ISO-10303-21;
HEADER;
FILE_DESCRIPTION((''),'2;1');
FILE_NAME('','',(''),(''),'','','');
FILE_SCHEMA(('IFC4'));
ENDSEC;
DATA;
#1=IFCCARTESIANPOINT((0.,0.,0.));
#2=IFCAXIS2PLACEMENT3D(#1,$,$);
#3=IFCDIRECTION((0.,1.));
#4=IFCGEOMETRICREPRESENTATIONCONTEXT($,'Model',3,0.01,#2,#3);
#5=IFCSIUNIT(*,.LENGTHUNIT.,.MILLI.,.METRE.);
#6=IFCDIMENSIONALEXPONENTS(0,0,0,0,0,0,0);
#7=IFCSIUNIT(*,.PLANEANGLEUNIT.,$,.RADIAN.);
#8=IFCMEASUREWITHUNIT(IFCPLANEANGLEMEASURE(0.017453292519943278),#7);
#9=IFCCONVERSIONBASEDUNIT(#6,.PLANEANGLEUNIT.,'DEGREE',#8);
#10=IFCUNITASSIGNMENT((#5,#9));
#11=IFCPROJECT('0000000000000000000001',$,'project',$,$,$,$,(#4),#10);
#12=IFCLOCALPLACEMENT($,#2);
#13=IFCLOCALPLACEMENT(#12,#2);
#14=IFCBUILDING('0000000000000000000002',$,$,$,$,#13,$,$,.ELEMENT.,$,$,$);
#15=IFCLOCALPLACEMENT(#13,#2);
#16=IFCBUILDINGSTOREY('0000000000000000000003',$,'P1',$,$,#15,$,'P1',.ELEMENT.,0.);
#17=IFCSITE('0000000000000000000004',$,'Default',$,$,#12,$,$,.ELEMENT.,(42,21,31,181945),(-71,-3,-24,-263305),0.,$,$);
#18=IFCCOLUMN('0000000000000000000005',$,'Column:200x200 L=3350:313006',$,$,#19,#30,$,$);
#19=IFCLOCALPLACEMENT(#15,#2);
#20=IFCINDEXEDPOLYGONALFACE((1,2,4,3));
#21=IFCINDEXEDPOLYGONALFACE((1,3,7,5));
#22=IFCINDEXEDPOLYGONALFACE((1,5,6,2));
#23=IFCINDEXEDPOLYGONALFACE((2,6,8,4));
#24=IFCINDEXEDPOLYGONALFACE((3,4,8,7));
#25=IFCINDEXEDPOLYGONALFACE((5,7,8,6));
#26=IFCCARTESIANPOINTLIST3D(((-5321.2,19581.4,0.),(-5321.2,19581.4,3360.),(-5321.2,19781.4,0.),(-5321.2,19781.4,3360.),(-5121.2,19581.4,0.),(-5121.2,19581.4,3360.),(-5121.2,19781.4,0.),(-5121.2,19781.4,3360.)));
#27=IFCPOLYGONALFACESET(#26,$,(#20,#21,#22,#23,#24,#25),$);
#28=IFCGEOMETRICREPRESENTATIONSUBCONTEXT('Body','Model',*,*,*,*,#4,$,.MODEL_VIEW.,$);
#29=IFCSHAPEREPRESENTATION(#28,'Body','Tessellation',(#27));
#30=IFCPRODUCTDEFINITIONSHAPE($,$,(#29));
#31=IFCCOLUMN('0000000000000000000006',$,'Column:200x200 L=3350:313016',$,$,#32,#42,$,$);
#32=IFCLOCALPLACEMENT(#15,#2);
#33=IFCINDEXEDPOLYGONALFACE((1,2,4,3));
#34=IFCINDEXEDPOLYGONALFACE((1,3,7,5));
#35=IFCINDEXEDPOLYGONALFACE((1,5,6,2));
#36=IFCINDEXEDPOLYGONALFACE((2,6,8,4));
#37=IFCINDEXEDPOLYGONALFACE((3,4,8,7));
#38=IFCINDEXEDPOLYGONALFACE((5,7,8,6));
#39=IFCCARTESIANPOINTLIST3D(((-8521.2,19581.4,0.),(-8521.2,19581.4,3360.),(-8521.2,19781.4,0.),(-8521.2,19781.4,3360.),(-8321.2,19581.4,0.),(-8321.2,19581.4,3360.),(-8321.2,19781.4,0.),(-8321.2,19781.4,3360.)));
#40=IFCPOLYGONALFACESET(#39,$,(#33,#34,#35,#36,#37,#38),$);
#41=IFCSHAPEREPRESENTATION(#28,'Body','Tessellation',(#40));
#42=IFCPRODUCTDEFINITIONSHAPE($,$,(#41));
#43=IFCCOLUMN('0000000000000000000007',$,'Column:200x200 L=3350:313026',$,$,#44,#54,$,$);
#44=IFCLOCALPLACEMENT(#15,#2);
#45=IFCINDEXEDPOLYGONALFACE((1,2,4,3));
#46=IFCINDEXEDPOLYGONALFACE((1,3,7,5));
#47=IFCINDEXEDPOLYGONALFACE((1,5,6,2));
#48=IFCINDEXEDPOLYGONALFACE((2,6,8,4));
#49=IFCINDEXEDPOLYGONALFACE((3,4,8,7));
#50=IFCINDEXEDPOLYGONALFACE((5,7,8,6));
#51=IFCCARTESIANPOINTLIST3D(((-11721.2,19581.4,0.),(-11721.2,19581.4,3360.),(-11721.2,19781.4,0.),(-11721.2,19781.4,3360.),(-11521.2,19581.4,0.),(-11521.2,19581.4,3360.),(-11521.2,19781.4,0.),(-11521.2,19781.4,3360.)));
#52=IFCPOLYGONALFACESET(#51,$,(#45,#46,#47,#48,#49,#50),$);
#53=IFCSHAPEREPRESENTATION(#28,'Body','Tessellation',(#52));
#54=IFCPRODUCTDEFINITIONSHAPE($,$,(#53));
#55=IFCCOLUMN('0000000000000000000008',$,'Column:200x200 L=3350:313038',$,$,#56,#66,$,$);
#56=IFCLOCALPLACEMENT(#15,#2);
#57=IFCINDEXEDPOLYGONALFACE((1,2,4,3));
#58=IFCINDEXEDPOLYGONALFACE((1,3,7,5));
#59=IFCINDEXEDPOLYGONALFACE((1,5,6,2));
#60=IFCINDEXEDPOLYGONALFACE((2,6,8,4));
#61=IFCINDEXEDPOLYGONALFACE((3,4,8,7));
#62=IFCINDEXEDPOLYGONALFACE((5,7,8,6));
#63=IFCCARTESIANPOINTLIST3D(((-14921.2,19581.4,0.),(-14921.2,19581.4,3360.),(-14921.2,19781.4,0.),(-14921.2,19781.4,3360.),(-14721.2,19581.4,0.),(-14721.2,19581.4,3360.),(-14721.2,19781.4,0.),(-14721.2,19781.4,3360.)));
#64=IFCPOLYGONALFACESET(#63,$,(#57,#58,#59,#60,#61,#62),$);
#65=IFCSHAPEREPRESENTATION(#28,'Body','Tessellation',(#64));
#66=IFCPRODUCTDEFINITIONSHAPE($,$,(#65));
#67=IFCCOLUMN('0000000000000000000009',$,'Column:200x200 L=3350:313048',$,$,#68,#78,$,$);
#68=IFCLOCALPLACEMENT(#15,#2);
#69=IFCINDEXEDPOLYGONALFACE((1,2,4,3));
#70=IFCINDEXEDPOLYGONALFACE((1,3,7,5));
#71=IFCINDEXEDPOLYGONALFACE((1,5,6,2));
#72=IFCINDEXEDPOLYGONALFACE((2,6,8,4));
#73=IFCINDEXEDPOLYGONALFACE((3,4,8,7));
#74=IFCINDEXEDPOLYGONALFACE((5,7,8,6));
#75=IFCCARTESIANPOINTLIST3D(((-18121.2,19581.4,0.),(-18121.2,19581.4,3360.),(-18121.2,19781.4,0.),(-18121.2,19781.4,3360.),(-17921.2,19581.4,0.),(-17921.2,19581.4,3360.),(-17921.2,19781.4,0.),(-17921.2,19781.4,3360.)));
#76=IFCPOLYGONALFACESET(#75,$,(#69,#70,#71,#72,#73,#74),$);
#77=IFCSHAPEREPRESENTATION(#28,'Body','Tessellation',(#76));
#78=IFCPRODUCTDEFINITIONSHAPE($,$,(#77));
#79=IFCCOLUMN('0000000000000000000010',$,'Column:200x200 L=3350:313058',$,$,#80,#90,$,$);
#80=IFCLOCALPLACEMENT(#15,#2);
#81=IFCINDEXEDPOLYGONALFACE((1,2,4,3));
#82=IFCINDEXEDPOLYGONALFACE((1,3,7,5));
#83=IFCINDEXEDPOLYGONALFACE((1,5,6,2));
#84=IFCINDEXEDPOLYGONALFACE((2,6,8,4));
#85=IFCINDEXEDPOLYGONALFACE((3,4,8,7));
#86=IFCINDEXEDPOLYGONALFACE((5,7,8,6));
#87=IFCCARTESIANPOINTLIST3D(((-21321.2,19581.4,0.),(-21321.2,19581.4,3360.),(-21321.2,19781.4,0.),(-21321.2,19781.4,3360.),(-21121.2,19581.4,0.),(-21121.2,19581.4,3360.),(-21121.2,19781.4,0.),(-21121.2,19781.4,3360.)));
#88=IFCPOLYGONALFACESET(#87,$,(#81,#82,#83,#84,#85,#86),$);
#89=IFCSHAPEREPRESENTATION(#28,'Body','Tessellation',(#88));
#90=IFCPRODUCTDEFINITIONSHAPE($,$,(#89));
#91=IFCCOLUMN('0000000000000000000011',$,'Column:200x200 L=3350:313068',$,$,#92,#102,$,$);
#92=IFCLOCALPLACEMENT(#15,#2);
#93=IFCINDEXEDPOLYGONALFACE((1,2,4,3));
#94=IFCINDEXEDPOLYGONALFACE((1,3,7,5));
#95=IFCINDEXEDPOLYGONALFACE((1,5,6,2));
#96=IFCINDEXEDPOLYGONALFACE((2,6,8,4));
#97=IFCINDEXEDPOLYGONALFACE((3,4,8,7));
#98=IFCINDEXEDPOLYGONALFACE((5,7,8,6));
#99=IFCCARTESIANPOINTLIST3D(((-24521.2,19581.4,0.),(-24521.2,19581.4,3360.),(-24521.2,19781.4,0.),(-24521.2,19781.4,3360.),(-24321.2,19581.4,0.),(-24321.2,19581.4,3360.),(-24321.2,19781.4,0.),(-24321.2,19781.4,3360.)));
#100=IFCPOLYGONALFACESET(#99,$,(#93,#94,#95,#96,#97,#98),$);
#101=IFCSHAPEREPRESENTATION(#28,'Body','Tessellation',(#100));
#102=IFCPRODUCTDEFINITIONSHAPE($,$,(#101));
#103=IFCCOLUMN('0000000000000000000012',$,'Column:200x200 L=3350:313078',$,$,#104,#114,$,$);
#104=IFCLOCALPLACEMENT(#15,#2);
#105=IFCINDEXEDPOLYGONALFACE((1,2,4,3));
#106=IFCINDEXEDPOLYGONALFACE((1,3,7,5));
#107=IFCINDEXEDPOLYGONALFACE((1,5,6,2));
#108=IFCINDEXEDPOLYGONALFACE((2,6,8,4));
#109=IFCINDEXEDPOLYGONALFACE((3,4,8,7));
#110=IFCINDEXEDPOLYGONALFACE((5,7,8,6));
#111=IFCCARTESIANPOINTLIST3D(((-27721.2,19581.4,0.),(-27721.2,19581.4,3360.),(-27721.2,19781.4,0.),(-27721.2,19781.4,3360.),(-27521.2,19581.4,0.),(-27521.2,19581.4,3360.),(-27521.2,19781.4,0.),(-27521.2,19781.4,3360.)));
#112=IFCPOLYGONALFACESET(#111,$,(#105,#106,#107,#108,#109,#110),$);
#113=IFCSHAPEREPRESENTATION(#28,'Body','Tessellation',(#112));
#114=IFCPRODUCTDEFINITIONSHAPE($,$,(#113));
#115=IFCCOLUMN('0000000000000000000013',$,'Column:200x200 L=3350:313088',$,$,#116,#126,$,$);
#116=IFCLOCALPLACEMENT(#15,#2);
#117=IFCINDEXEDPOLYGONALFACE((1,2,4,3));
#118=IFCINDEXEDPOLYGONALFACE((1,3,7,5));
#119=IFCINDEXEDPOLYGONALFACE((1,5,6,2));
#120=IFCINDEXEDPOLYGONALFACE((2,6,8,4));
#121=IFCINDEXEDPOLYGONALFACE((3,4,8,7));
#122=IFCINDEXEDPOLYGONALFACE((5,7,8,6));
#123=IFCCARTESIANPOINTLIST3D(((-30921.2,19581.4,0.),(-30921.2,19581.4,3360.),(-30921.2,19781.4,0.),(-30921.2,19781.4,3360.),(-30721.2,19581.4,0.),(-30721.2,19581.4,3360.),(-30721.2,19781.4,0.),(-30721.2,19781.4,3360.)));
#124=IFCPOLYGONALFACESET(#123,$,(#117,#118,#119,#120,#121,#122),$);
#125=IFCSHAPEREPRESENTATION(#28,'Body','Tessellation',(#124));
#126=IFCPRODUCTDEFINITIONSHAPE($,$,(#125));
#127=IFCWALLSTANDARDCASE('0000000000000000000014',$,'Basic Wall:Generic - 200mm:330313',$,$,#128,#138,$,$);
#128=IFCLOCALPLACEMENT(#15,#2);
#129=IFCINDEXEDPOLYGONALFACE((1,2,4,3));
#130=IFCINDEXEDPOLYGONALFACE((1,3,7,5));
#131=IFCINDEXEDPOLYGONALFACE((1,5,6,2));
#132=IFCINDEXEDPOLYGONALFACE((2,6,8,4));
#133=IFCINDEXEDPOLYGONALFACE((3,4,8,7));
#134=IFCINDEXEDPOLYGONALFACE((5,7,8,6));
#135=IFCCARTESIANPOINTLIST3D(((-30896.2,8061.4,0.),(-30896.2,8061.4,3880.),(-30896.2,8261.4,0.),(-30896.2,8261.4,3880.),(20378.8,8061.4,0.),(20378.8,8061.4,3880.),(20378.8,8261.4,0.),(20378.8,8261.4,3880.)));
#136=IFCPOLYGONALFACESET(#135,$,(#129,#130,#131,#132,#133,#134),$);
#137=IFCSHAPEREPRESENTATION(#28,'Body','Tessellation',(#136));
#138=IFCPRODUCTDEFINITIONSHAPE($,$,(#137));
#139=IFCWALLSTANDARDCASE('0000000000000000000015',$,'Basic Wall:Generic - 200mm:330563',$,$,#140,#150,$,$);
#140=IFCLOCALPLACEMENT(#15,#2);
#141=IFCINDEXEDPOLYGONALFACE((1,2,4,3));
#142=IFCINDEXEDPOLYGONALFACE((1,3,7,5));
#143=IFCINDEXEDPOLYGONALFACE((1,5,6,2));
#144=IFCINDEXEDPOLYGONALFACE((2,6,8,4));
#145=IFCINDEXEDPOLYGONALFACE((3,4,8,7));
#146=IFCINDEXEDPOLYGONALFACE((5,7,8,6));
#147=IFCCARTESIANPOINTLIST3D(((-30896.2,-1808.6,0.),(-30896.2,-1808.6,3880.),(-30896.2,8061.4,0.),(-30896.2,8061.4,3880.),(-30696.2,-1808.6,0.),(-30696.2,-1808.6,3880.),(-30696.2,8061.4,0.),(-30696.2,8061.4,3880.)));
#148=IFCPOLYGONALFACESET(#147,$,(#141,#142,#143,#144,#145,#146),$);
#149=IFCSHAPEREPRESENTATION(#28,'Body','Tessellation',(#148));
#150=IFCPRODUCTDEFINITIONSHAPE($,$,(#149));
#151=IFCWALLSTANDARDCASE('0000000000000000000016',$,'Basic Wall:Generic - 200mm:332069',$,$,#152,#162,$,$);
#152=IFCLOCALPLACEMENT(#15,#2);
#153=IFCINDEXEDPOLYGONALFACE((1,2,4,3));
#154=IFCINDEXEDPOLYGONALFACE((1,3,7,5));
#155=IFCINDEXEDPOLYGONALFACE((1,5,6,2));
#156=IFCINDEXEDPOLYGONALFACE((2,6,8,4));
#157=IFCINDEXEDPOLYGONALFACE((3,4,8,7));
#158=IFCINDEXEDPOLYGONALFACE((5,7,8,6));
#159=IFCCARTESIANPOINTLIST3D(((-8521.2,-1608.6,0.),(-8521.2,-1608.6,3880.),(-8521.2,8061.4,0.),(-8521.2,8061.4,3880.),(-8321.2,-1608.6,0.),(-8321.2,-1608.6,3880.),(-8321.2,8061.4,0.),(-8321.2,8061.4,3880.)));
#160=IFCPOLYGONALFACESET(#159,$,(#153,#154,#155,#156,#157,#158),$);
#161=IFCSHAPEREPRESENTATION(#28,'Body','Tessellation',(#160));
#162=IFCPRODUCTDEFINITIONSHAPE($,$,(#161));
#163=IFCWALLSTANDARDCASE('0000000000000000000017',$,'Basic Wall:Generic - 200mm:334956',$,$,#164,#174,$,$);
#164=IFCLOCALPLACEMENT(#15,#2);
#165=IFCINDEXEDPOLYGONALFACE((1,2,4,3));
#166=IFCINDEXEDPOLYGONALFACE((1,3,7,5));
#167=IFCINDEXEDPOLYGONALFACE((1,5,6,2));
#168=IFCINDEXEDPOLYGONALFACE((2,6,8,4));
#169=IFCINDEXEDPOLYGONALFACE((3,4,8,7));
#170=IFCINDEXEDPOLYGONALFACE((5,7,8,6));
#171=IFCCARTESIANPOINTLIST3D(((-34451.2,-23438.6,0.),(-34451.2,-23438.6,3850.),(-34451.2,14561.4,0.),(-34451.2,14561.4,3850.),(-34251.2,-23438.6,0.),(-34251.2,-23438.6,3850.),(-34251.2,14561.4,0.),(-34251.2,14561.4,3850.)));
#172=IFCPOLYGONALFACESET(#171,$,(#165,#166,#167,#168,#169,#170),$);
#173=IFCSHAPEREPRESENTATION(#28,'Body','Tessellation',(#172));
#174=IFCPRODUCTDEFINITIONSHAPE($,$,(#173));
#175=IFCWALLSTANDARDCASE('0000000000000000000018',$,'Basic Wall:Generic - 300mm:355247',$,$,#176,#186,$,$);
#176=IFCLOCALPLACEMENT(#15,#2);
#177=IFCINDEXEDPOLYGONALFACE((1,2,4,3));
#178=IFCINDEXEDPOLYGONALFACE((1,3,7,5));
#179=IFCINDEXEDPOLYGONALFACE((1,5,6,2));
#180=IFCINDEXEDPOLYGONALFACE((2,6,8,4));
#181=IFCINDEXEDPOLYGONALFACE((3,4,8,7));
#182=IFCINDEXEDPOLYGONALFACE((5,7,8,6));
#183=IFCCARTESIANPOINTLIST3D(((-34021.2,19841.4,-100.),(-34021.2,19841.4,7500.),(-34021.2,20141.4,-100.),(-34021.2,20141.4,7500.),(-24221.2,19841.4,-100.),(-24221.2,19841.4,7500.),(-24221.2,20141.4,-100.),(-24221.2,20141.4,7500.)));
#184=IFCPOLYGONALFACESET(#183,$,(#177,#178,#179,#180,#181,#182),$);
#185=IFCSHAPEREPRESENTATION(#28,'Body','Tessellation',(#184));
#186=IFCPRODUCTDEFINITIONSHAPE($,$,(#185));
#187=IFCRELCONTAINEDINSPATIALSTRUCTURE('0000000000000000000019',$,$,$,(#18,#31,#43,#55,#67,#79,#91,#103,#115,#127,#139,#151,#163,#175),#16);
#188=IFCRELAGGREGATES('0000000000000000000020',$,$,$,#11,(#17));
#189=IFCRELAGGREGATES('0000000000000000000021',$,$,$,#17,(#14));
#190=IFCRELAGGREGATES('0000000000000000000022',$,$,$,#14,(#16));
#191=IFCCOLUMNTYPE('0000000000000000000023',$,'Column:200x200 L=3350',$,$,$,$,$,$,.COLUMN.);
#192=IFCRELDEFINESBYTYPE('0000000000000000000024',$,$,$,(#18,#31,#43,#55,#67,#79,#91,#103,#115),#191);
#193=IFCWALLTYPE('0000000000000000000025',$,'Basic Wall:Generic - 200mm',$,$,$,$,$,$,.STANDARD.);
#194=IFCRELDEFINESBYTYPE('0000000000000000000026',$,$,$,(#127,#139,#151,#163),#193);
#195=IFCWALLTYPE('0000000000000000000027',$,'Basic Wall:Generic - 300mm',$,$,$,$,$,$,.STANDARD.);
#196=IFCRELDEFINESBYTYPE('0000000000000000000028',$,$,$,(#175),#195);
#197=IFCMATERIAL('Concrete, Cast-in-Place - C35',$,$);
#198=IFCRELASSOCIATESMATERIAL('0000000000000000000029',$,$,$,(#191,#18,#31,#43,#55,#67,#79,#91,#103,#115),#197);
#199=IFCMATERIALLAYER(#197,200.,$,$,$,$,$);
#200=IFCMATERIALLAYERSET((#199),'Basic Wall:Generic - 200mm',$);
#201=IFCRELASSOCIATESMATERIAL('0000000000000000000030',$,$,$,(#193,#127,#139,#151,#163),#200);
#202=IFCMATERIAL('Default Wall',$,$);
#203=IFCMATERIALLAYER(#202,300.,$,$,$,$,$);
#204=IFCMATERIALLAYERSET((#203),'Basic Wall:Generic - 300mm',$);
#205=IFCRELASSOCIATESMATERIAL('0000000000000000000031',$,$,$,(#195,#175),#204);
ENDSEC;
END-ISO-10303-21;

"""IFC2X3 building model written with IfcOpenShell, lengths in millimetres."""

from ifc_helpers import new_model, entity, si_unit, converted_unit, direction, frame, frame_2d, origin, place, context, subcontext, project, spatial, rectangle, extrude, source, transform, mapped, material, layer, layer_set, layer_usage, type_object, type_shapes, element, save


model = new_model("IFC2X3")

# Units and contexts
model_context = context("Model", 3, precision=0.01, world=origin(), true_north=direction((0.0, 1.0)))
body_context = subcontext(model_context, "Body", "Model", "MODEL_VIEW")
ifc_project = project(units=[si_unit("LENGTHUNIT", "METRE", prefix="MILLI"), converted_unit("PLANEANGLEUNIT", "DEGREE", entity("IfcPlaneAngleMeasure", 0.017453292519943278), si_unit("PLANEANGLEUNIT", "RADIAN"), dimensions=[0, 0, 0, 0, 0, 0, 0])], contexts=[model_context])

# Site, building, storey
site_placement = place(None, origin())
site = spatial("IfcSite", under=ifc_project, at=site_placement, Name="Default", CompositionType="ELEMENT", RefLatitude=(42, 21, 31, 181945), RefLongitude=(-71, -3, -24, -263305), RefElevation=0.0)
building_placement = place(site_placement, origin())
building = spatial("IfcBuilding", under=site, at=building_placement, CompositionType="ELEMENT")
storey_placement = place(building_placement, origin())
storey = spatial("IfcBuildingStorey", under=building, at=storey_placement, Name="P1", LongName="P1", CompositionType="ELEMENT", Elevation=0.0)

# Columns
ifc_material_1 = material(Name="Concrete, Cast-in-Place - C35")
column_type_1 = type_object("IfcColumnType", Name="Column:200x200 L=3350", PredefinedType="COLUMN", material=ifc_material_1)
shared_shape_1 = source(origin(), body_context, "Body", "SweptSolid", [
    extrude(rectangle(XDim=200.0, YDim=200.0, at=frame_2d((0.0, 0.0), x_axis=(1.0, 0.0))), frame((0.0, 0.0, 0.0), z_axis=(0.0, 0.0, 1.0), x_axis=(-1.0, 0.0, 0.0)), (0.0, 0.0, 1.0), 3360.0),
])
type_shapes(column_type_1, [shared_shape_1])
for number, where, name in (
    (1, (-5221.2, 19681.4, 0.0), "Column:200x200 L=3350:313006"),
    (2, (-8421.2, 19681.4, 0.0), "Column:200x200 L=3350:313016"),
    (3, (-11621.2, 19681.4, 0.0), "Column:200x200 L=3350:313026"),
    (4, (-14821.2, 19681.4, 0.0), "Column:200x200 L=3350:313038"),
    (5, (-18021.2, 19681.4, 0.0), "Column:200x200 L=3350:313048"),
    (6, (-21221.2, 19681.4, 0.0), "Column:200x200 L=3350:313058"),
    (7, (-24421.2, 19681.4, 0.0), "Column:200x200 L=3350:313068"),
    (8, (-27621.2, 19681.4, 0.0), "Column:200x200 L=3350:313078"),
    (9, (-30821.2, 19681.4, 0.0), "Column:200x200 L=3350:313088"),
):
    element("IfcColumn", number, at=place(storey_placement, frame(where)), inside=storey, type_object=column_type_1, material=ifc_material_1, Name=name, context=body_context, shape_type="MappedRepresentation", body=[
        mapped(shared_shape_1, transform((0.0, 0.0, 0.0), scale=1.0)),
    ])

# Walls
ifc_layer_1 = layer(ifc_material_1, 200.0)
ifc_layer_set_1 = layer_set([ifc_layer_1], Name="Basic Wall:Generic - 200mm")
ifc_layer_usage_1 = layer_usage(ifc_layer_set_1, "AXIS2", "NEGATIVE", 100.0)
wall_type_1 = type_object("IfcWallType", Name="Basic Wall:Generic - 200mm", PredefinedType="STANDARD", material=ifc_layer_set_1)
wall_1_placement = place(storey_placement, frame((-30896.2, 8161.4, 0.0)))
element("IfcWallStandardCase", 10, at=wall_1_placement, inside=storey, type_object=wall_type_1, material=ifc_layer_usage_1, Name="Basic Wall:Generic - 200mm:330313", context=body_context, shape_type="SweptSolid", body=[
    extrude(rectangle(XDim=51275.0, YDim=200.0, at=frame_2d((25637.5, 0.0), x_axis=(-1.0, 0.0))), origin(), (0.0, 0.0, 1.0), 3880.0),
])
ifc_layer_usage_2 = layer_usage(ifc_layer_set_1, "AXIS2", "NEGATIVE", 100.0)
wall_2_placement = place(storey_placement, frame((-30796.2, 8061.4, 0.0), z_axis=(0.0, 0.0, 1.0), x_axis=(0.0, -1.0, 0.0)))
element("IfcWallStandardCase", 11, at=wall_2_placement, inside=storey, type_object=wall_type_1, material=ifc_layer_usage_2, Name="Basic Wall:Generic - 200mm:330563", context=body_context, shape_type="SweptSolid", body=[
    extrude(rectangle(XDim=9870.0, YDim=200.0, at=frame_2d((4935.0, 0.0), x_axis=(-1.0, 0.0))), origin(), (0.0, 0.0, 1.0), 3880.0),
])
ifc_layer_usage_3 = layer_usage(ifc_layer_set_1, "AXIS2", "NEGATIVE", 100.0)
wall_3_placement = place(storey_placement, frame((-8421.2, 8061.4, 0.0), z_axis=(0.0, 0.0, 1.0), x_axis=(0.0, -1.0, 0.0)))
element("IfcWallStandardCase", 12, at=wall_3_placement, inside=storey, type_object=wall_type_1, material=ifc_layer_usage_3, Name="Basic Wall:Generic - 200mm:332069", context=body_context, shape_type="SweptSolid", body=[
    extrude(rectangle(XDim=9670.0, YDim=200.0, at=frame_2d((4835.0, 0.0), x_axis=(-1.0, 0.0))), origin(), (0.0, 0.0, 1.0), 3880.0),
])
ifc_layer_usage_4 = layer_usage(ifc_layer_set_1, "AXIS2", "NEGATIVE", 100.0)
wall_4_placement = place(storey_placement, frame((-34351.2, 14561.4, 0.0), z_axis=(0.0, 0.0, 1.0), x_axis=(0.0, -1.0, 0.0)))
element("IfcWallStandardCase", 13, at=wall_4_placement, inside=storey, type_object=wall_type_1, material=ifc_layer_usage_4, Name="Basic Wall:Generic - 200mm:334956", context=body_context, shape_type="SweptSolid", body=[
    extrude(rectangle(XDim=38000.0, YDim=200.0, at=frame_2d((19000.0, 0.0), x_axis=(-1.0, 0.0))), origin(), (0.0, 0.0, 1.0), 3850.0),
])
ifc_material_2 = material(Name="Default Wall")
ifc_layer_2 = layer(ifc_material_2, 300.0)
ifc_layer_set_2 = layer_set([ifc_layer_2], Name="Basic Wall:Generic - 300mm")
ifc_layer_usage_5 = layer_usage(ifc_layer_set_2, "AXIS2", "NEGATIVE", 150.0)
wall_type_2 = type_object("IfcWallType", Name="Basic Wall:Generic - 300mm", PredefinedType="STANDARD", material=ifc_layer_set_2)
wall_5_placement = place(storey_placement, frame((-34021.2, 19991.4, -100.0)))
element("IfcWallStandardCase", 14, at=wall_5_placement, inside=storey, type_object=wall_type_2, material=ifc_layer_usage_5, Name="Basic Wall:Generic - 300mm:355247", context=body_context, shape_type="SweptSolid", body=[
    extrude(rectangle(XDim=9800.0, YDim=300.0, at=frame_2d((4900.0, 0.0), x_axis=(-1.0, 0.0))), origin(), (0.0, 0.0, 1.0), 7600.0),
])

save(model, "model.ifc")
